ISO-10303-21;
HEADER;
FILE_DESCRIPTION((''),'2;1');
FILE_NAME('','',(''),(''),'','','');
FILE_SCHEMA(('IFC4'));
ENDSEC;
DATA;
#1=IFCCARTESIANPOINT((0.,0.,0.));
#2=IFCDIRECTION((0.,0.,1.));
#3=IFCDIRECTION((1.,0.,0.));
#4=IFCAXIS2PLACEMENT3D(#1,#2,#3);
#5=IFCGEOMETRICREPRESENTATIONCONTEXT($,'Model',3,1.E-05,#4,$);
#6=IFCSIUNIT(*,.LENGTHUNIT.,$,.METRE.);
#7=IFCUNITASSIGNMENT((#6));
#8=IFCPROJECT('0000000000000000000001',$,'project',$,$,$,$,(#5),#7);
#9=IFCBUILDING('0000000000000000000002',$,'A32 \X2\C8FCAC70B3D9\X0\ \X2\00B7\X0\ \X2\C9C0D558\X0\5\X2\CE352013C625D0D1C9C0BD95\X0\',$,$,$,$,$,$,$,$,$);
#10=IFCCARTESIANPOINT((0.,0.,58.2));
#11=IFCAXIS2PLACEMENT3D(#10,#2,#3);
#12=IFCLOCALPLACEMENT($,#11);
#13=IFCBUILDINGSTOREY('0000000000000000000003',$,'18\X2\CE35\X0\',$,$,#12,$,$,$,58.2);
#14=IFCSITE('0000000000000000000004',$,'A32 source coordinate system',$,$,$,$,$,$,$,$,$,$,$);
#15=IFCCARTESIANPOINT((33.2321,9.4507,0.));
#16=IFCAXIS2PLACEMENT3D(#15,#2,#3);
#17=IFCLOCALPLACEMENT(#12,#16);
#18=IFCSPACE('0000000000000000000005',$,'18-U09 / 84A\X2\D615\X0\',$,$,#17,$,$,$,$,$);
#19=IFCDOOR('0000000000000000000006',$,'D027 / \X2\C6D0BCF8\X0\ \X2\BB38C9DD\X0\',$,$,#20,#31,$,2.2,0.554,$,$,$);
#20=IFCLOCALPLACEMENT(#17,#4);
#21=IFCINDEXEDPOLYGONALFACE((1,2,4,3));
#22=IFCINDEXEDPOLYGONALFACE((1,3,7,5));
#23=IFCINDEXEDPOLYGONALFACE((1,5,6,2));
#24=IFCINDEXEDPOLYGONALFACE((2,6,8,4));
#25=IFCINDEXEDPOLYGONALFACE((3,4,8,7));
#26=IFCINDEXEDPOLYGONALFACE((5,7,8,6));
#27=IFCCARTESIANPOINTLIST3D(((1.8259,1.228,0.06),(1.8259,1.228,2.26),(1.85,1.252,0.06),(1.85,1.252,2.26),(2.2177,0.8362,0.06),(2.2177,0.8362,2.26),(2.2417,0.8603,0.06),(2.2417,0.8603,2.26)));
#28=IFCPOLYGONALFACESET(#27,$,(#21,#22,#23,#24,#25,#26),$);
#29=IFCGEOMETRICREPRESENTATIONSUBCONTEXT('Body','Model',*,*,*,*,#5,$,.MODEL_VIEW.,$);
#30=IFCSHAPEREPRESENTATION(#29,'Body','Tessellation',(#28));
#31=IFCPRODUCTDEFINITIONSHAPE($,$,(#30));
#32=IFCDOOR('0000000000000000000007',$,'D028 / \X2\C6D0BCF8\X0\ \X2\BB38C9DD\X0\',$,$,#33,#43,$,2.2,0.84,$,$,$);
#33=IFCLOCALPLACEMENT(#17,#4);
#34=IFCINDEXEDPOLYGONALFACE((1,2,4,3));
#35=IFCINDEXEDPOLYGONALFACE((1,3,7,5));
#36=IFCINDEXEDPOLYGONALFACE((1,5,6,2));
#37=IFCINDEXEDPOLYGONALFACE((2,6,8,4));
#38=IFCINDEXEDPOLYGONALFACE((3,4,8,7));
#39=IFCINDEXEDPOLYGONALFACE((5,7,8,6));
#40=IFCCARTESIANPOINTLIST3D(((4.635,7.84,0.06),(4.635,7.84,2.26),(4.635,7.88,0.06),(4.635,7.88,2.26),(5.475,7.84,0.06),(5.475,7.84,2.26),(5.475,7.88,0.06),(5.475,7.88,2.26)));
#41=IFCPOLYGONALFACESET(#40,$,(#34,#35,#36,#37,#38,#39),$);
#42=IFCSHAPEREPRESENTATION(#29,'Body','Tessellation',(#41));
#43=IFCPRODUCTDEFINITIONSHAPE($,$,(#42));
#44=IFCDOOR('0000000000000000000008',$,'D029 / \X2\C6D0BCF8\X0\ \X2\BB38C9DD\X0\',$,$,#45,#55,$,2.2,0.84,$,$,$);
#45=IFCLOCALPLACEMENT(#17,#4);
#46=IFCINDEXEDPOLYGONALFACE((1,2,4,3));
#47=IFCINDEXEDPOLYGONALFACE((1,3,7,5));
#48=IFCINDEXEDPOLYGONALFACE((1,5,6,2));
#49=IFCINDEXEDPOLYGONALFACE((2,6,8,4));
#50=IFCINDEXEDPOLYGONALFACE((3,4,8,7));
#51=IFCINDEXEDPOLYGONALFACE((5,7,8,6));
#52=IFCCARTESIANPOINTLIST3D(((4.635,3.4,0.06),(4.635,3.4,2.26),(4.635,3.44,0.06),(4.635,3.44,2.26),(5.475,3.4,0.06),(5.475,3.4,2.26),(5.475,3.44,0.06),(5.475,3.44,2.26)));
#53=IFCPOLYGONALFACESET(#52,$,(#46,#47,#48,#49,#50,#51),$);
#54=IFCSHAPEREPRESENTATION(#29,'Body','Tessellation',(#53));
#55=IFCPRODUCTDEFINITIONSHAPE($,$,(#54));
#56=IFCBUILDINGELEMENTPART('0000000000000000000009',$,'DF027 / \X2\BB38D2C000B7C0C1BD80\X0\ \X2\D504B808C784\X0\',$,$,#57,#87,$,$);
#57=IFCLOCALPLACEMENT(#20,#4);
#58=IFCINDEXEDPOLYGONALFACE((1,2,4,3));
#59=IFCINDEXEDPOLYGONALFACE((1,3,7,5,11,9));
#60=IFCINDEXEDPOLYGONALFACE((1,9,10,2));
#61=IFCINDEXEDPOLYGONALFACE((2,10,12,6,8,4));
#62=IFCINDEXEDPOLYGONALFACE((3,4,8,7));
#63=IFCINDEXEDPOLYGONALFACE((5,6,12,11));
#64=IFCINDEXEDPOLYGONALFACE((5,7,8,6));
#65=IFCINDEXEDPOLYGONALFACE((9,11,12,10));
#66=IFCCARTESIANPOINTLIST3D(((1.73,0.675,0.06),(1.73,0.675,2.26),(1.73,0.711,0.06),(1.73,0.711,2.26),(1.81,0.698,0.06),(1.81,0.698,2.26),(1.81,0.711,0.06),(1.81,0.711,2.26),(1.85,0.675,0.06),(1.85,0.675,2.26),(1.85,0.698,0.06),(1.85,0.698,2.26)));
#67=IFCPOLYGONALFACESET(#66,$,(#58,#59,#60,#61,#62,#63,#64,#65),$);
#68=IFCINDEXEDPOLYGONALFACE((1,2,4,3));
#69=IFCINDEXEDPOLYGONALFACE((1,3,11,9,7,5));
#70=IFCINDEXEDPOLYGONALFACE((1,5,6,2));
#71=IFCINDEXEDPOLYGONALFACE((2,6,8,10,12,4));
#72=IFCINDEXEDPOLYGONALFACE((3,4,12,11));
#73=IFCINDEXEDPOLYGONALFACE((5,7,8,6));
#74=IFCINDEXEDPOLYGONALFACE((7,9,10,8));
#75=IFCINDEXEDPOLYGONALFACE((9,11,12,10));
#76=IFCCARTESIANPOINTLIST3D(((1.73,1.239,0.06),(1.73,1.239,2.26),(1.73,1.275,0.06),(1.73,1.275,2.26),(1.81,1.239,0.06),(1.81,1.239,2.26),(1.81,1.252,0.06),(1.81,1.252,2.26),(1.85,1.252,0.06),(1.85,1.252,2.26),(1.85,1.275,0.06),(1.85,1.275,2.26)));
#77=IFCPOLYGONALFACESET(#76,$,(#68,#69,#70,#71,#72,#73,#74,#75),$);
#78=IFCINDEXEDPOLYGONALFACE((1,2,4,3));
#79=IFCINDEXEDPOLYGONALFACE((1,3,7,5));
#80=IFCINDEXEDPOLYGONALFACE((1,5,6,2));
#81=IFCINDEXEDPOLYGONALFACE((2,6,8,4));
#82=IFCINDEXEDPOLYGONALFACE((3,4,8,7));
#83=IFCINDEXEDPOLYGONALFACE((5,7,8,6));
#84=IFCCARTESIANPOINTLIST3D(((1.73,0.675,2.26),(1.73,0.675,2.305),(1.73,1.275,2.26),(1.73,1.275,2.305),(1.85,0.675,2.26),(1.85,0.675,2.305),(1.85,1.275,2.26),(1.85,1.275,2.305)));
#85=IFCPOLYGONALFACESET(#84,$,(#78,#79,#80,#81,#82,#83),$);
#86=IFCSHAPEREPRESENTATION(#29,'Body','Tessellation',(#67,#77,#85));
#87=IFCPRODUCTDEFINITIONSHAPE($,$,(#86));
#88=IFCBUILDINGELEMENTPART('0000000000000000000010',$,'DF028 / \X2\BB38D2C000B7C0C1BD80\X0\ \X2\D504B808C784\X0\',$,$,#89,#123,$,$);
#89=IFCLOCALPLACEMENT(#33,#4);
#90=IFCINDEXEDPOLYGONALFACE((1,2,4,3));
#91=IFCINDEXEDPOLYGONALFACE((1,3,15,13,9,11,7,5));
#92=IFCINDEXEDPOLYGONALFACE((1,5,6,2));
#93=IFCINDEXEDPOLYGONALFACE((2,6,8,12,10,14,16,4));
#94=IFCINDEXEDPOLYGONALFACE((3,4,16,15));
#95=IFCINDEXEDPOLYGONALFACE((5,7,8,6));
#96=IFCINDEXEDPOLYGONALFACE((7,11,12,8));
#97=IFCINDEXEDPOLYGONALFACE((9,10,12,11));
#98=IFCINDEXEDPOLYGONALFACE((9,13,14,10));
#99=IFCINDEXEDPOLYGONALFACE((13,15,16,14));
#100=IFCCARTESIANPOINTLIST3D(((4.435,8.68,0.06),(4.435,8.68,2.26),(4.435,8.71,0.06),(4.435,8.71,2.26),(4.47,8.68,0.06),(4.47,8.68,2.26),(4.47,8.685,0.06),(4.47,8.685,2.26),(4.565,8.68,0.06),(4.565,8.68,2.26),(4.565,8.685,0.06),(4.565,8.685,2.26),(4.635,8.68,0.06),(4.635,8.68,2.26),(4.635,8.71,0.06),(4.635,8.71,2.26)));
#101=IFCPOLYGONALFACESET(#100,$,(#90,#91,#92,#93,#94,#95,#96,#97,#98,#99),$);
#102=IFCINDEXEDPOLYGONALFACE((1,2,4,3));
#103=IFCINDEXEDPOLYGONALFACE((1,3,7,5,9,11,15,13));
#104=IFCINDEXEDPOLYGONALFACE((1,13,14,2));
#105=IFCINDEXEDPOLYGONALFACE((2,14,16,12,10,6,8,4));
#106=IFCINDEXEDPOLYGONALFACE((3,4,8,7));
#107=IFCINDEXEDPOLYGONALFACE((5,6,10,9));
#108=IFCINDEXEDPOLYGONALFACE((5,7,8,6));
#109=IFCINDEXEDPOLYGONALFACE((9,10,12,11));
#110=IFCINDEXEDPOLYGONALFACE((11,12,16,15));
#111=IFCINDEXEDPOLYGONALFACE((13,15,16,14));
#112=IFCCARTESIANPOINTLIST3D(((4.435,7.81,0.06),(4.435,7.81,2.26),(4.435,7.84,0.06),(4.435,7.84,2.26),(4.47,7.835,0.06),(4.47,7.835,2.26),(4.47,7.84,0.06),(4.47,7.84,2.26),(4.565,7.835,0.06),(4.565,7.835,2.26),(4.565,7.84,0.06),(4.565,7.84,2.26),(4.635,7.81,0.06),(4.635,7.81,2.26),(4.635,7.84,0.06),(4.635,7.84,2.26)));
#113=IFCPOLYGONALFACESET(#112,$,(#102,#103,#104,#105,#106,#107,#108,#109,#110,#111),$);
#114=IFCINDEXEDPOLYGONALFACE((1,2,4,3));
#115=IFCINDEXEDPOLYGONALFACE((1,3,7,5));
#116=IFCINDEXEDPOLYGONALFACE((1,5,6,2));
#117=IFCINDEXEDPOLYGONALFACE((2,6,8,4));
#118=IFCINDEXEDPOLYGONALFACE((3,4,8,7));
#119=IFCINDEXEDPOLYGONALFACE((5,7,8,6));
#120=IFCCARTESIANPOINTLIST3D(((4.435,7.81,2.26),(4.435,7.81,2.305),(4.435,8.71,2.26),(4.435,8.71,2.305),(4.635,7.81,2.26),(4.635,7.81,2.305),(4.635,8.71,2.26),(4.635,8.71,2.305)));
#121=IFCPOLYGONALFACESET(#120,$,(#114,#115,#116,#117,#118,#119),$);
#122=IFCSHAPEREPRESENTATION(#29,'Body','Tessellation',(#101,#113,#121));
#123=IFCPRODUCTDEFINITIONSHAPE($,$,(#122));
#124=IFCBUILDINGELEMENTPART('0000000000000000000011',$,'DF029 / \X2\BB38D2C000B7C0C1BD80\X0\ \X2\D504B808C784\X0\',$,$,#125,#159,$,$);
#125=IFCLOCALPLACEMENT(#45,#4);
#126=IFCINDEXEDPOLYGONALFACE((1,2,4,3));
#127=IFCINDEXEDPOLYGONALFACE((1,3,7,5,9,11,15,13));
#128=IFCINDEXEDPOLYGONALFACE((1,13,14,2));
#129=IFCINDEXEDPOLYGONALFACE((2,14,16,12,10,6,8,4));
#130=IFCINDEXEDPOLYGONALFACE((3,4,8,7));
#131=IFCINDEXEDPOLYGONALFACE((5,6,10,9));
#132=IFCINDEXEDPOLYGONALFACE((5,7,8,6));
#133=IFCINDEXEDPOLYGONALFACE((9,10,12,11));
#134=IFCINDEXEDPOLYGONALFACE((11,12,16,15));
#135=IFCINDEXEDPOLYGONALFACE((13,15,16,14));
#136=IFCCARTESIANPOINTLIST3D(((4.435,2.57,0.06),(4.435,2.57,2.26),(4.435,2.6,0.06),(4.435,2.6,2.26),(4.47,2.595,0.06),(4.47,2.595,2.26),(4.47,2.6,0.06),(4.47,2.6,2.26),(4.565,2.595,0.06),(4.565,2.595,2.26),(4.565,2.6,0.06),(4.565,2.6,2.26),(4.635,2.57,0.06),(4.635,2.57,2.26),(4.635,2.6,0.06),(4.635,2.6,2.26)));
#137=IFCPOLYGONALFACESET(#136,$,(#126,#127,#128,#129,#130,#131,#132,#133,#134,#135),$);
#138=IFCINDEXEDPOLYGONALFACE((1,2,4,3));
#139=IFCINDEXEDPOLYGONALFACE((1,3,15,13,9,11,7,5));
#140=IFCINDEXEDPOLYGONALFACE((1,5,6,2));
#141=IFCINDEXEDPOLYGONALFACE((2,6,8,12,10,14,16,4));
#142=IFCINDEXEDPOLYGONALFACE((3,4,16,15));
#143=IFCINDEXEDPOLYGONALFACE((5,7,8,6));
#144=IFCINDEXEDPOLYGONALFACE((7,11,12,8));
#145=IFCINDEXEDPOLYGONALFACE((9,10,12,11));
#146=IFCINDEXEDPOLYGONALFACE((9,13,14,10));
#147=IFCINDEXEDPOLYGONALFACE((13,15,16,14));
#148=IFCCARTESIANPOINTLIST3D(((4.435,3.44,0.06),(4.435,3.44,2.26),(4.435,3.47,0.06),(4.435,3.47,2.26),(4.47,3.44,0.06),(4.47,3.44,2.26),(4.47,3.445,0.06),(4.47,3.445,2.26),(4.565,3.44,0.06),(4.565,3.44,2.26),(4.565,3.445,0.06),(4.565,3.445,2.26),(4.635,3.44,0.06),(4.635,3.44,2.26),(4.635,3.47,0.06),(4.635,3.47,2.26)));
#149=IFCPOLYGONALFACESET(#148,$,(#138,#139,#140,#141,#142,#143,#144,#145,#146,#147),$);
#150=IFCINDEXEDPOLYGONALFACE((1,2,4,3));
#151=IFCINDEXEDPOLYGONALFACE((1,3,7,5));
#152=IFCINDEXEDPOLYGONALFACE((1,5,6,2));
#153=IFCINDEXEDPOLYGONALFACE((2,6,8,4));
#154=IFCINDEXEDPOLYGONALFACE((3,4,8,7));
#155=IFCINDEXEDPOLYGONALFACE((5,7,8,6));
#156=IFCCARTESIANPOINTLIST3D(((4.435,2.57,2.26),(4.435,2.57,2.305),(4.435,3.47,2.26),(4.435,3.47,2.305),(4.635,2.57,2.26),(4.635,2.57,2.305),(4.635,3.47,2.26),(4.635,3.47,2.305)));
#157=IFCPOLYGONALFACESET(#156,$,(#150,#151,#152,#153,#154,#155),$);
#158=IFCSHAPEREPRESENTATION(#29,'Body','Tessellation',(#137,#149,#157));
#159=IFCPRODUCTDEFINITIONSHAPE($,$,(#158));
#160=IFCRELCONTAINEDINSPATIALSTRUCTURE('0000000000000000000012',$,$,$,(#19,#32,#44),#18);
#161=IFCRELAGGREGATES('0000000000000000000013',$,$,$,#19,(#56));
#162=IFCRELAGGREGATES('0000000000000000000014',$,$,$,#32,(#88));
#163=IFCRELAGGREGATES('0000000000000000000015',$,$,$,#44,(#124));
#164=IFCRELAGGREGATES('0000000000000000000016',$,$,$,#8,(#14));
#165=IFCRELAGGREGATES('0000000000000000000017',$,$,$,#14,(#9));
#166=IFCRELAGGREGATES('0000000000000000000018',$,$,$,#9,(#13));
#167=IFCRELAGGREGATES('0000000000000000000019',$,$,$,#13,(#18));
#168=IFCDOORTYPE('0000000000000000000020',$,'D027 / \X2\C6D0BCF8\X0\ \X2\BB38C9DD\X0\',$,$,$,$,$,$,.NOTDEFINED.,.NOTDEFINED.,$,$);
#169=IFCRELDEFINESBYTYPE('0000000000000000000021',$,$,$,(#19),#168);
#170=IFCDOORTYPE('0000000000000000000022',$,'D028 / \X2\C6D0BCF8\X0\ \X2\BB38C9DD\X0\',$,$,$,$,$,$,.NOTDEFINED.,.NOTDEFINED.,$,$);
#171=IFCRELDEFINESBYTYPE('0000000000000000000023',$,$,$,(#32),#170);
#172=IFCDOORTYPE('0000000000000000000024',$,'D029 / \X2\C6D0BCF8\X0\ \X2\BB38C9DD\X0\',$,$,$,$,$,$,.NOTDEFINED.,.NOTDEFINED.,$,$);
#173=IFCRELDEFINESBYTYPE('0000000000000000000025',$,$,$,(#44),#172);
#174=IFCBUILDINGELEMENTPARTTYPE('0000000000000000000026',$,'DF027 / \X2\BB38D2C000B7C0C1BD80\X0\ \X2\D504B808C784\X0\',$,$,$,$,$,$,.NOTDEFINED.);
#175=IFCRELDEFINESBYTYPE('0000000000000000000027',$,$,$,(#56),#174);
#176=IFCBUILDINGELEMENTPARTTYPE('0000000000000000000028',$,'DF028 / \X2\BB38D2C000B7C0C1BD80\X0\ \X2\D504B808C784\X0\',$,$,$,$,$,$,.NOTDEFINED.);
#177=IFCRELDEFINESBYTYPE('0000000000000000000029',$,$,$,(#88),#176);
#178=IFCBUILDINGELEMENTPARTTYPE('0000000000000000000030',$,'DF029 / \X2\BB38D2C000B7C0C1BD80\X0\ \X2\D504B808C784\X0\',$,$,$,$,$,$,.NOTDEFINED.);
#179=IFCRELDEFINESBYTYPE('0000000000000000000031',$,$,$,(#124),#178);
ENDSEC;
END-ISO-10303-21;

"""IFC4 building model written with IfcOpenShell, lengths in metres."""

from ifc_helpers import new_model, si_unit, frame, origin, origin_with_axes, place, context, subcontext, project, spatial, polyline, outline, extrude, source, transform, mapped, type_object, type_shapes, element, aggregate, save


model = new_model("IFC4")

# Units and contexts
model_context = context("Model", 3, precision=1e-05, world=origin_with_axes())
body_context = subcontext(model_context, "Body", "Model", "MODEL_VIEW")
ifc_project = project(units=[si_unit("LENGTHUNIT", "METRE")], contexts=[model_context])

# Site, building, storey, space
storey_placement = place(None, frame((0.0, 0.0, 58.2), z_axis=(0.0, 0.0, 1.0), x_axis=(1.0, 0.0, 0.0)))
space_placement = place(storey_placement, frame((33.2321, 9.4507, 0.0), z_axis=(0.0, 0.0, 1.0), x_axis=(1.0, 0.0, 0.0)))
site = spatial("IfcSite", under=ifc_project, Name="A32 source coordinate system")
building = spatial("IfcBuilding", under=site, Name="A32 주거동 · 지하5층–옥탑지붕")
storey = spatial("IfcBuildingStorey", under=building, at=storey_placement, Name="18층", Elevation=58.2)
space = spatial("IfcSpace", under=storey, at=space_placement, Name="18-U09 / 84A형")

# Doors
door_type_1 = type_object("IfcDoorType", Name="D027 / 원본 문짝", OperationType="NOTDEFINED", PredefinedType="NOTDEFINED")
shared_shape_1 = source(origin(), body_context, "Body", "SweptSolid", [
    extrude(outline(polyline([(1.85, 1.252), (2.2417, 0.8603), (2.2177, 0.8362), (1.8259, 1.228), (1.85, 1.252)])), frame((0.0, 0.0, 0.06)), (0.0, 0.0, 1.0), 2.2),
])
type_shapes(door_type_1, [shared_shape_1])
door_1_placement = place(space_placement, origin_with_axes())
door_1 = element("IfcDoor", 1, at=door_1_placement, inside=space, type_object=door_type_1, Name="D027 / 원본 문짝", OverallHeight=2.2, OverallWidth=0.554, context=body_context, shape_type="MappedRepresentation", body=[
    mapped(shared_shape_1, transform((0.0, 0.0, 0.0), scale=1.0)),
])
door_type_2 = type_object("IfcDoorType", Name="D028 / 원본 문짝", OperationType="NOTDEFINED", PredefinedType="NOTDEFINED")
shared_shape_2 = source(origin(), body_context, "Body", "SweptSolid", [
    extrude(outline(polyline([(5.475, 7.88), (5.475, 7.84), (4.635, 7.84), (4.635, 7.88), (5.475, 7.88)])), frame((0.0, 0.0, 0.06)), (0.0, 0.0, 1.0), 2.2),
])
type_shapes(door_type_2, [shared_shape_2])
door_2_placement = place(space_placement, origin_with_axes())
door_2 = element("IfcDoor", 2, at=door_2_placement, inside=space, type_object=door_type_2, Name="D028 / 원본 문짝", OverallHeight=2.2, OverallWidth=0.84, context=body_context, shape_type="MappedRepresentation", body=[
    mapped(shared_shape_2, transform((0.0, 0.0, 0.0), scale=1.0)),
])
door_type_3 = type_object("IfcDoorType", Name="D029 / 원본 문짝", OperationType="NOTDEFINED", PredefinedType="NOTDEFINED")
shared_shape_3 = source(origin(), body_context, "Body", "SweptSolid", [
    extrude(outline(polyline([(4.635, 3.44), (5.475, 3.44), (5.475, 3.4), (4.635, 3.4), (4.635, 3.44)])), frame((0.0, 0.0, 0.06)), (0.0, 0.0, 1.0), 2.2),
])
type_shapes(door_type_3, [shared_shape_3])
door_3_placement = place(space_placement, origin_with_axes())
door_3 = element("IfcDoor", 3, at=door_3_placement, inside=space, type_object=door_type_3, Name="D029 / 원본 문짝", OverallHeight=2.2, OverallWidth=0.84, context=body_context, shape_type="MappedRepresentation", body=[
    mapped(shared_shape_3, transform((0.0, 0.0, 0.0), scale=1.0)),
])

# Building element parts
building_element_part_type_1 = type_object("IfcBuildingElementPartType", Name="DF027 / 문틀·상부 프레임", PredefinedType="NOTDEFINED")
shared_shape_4 = source(origin(), body_context, "Body", "SweptSolid", [
    extrude(outline(polyline([(1.73, 0.711), (1.81, 0.711), (1.81, 0.698), (1.85, 0.698), (1.85, 0.675), (1.73, 0.675), (1.73, 0.711)])), frame((0.0, 0.0, 0.06)), (0.0, 0.0, 1.0), 2.2),
    extrude(outline(polyline([(1.85, 1.275), (1.85, 1.252), (1.81, 1.252), (1.81, 1.239), (1.73, 1.239), (1.73, 1.275), (1.85, 1.275)])), frame((0.0, 0.0, 0.06)), (0.0, 0.0, 1.0), 2.2),
    extrude(outline(polyline([(1.73, 0.675), (1.73, 1.275), (1.85, 1.275), (1.85, 0.675), (1.73, 0.675)])), frame((0.0, 0.0, 2.26)), (0.0, 0.0, 1.0), 0.045),
])
type_shapes(building_element_part_type_1, [shared_shape_4])
building_element_part_1_placement = place(door_1_placement, origin_with_axes())
building_element_part_1 = element("IfcBuildingElementPart", 4, at=building_element_part_1_placement, type_object=building_element_part_type_1, Name="DF027 / 문틀·상부 프레임", context=body_context, shape_type="MappedRepresentation", body=[
    mapped(shared_shape_4, transform((0.0, 0.0, 0.0), scale=1.0)),
])
aggregate(door_1, [building_element_part_1])
building_element_part_type_2 = type_object("IfcBuildingElementPartType", Name="DF028 / 문틀·상부 프레임", PredefinedType="NOTDEFINED")
shared_shape_5 = source(origin(), body_context, "Body", "SweptSolid", [
    extrude(outline(polyline([(4.635, 8.68), (4.565, 8.68), (4.565, 8.685), (4.47, 8.685), (4.47, 8.68), (4.435, 8.68), (4.435, 8.71), (4.635, 8.71), (4.635, 8.68)])), frame((0.0, 0.0, 0.06)), (0.0, 0.0, 1.0), 2.2),
    extrude(outline(polyline([(4.435, 7.81), (4.435, 7.84), (4.47, 7.84), (4.47, 7.835), (4.565, 7.835), (4.565, 7.84), (4.635, 7.84), (4.635, 7.81), (4.435, 7.81)])), frame((0.0, 0.0, 0.06)), (0.0, 0.0, 1.0), 2.2),
    extrude(outline(polyline([(4.435, 7.81), (4.435, 8.71), (4.635, 8.71), (4.635, 7.81), (4.435, 7.81)])), frame((0.0, 0.0, 2.26)), (0.0, 0.0, 1.0), 0.045),
])
type_shapes(building_element_part_type_2, [shared_shape_5])
building_element_part_2_placement = place(door_2_placement, origin_with_axes())
building_element_part_2 = element("IfcBuildingElementPart", 5, at=building_element_part_2_placement, type_object=building_element_part_type_2, Name="DF028 / 문틀·상부 프레임", context=body_context, shape_type="MappedRepresentation", body=[
    mapped(shared_shape_5, transform((0.0, 0.0, 0.0), scale=1.0)),
])
aggregate(door_2, [building_element_part_2])
building_element_part_type_3 = type_object("IfcBuildingElementPartType", Name="DF029 / 문틀·상부 프레임", PredefinedType="NOTDEFINED")
shared_shape_6 = source(origin(), body_context, "Body", "SweptSolid", [
    extrude(outline(polyline([(4.435, 2.57), (4.435, 2.6), (4.47, 2.6), (4.47, 2.595), (4.565, 2.595), (4.565, 2.6), (4.635, 2.6), (4.635, 2.57), (4.435, 2.57)])), frame((0.0, 0.0, 0.06)), (0.0, 0.0, 1.0), 2.2),
    extrude(outline(polyline([(4.635, 3.44), (4.565, 3.44), (4.565, 3.445), (4.47, 3.445), (4.47, 3.44), (4.435, 3.44), (4.435, 3.47), (4.635, 3.47), (4.635, 3.44)])), frame((0.0, 0.0, 0.06)), (0.0, 0.0, 1.0), 2.2),
    extrude(outline(polyline([(4.435, 2.57), (4.435, 3.47), (4.635, 3.47), (4.635, 2.57), (4.435, 2.57)])), frame((0.0, 0.0, 2.26)), (0.0, 0.0, 1.0), 0.045),
])
type_shapes(building_element_part_type_3, [shared_shape_6])
building_element_part_3_placement = place(door_3_placement, origin_with_axes())
building_element_part_3 = element("IfcBuildingElementPart", 6, at=building_element_part_3_placement, type_object=building_element_part_type_3, Name="DF029 / 문틀·상부 프레임", context=body_context, shape_type="MappedRepresentation", body=[
    mapped(shared_shape_6, transform((0.0, 0.0, 0.0), scale=1.0)),
])
aggregate(door_3, [building_element_part_3])

save(model, "model.ifc")
